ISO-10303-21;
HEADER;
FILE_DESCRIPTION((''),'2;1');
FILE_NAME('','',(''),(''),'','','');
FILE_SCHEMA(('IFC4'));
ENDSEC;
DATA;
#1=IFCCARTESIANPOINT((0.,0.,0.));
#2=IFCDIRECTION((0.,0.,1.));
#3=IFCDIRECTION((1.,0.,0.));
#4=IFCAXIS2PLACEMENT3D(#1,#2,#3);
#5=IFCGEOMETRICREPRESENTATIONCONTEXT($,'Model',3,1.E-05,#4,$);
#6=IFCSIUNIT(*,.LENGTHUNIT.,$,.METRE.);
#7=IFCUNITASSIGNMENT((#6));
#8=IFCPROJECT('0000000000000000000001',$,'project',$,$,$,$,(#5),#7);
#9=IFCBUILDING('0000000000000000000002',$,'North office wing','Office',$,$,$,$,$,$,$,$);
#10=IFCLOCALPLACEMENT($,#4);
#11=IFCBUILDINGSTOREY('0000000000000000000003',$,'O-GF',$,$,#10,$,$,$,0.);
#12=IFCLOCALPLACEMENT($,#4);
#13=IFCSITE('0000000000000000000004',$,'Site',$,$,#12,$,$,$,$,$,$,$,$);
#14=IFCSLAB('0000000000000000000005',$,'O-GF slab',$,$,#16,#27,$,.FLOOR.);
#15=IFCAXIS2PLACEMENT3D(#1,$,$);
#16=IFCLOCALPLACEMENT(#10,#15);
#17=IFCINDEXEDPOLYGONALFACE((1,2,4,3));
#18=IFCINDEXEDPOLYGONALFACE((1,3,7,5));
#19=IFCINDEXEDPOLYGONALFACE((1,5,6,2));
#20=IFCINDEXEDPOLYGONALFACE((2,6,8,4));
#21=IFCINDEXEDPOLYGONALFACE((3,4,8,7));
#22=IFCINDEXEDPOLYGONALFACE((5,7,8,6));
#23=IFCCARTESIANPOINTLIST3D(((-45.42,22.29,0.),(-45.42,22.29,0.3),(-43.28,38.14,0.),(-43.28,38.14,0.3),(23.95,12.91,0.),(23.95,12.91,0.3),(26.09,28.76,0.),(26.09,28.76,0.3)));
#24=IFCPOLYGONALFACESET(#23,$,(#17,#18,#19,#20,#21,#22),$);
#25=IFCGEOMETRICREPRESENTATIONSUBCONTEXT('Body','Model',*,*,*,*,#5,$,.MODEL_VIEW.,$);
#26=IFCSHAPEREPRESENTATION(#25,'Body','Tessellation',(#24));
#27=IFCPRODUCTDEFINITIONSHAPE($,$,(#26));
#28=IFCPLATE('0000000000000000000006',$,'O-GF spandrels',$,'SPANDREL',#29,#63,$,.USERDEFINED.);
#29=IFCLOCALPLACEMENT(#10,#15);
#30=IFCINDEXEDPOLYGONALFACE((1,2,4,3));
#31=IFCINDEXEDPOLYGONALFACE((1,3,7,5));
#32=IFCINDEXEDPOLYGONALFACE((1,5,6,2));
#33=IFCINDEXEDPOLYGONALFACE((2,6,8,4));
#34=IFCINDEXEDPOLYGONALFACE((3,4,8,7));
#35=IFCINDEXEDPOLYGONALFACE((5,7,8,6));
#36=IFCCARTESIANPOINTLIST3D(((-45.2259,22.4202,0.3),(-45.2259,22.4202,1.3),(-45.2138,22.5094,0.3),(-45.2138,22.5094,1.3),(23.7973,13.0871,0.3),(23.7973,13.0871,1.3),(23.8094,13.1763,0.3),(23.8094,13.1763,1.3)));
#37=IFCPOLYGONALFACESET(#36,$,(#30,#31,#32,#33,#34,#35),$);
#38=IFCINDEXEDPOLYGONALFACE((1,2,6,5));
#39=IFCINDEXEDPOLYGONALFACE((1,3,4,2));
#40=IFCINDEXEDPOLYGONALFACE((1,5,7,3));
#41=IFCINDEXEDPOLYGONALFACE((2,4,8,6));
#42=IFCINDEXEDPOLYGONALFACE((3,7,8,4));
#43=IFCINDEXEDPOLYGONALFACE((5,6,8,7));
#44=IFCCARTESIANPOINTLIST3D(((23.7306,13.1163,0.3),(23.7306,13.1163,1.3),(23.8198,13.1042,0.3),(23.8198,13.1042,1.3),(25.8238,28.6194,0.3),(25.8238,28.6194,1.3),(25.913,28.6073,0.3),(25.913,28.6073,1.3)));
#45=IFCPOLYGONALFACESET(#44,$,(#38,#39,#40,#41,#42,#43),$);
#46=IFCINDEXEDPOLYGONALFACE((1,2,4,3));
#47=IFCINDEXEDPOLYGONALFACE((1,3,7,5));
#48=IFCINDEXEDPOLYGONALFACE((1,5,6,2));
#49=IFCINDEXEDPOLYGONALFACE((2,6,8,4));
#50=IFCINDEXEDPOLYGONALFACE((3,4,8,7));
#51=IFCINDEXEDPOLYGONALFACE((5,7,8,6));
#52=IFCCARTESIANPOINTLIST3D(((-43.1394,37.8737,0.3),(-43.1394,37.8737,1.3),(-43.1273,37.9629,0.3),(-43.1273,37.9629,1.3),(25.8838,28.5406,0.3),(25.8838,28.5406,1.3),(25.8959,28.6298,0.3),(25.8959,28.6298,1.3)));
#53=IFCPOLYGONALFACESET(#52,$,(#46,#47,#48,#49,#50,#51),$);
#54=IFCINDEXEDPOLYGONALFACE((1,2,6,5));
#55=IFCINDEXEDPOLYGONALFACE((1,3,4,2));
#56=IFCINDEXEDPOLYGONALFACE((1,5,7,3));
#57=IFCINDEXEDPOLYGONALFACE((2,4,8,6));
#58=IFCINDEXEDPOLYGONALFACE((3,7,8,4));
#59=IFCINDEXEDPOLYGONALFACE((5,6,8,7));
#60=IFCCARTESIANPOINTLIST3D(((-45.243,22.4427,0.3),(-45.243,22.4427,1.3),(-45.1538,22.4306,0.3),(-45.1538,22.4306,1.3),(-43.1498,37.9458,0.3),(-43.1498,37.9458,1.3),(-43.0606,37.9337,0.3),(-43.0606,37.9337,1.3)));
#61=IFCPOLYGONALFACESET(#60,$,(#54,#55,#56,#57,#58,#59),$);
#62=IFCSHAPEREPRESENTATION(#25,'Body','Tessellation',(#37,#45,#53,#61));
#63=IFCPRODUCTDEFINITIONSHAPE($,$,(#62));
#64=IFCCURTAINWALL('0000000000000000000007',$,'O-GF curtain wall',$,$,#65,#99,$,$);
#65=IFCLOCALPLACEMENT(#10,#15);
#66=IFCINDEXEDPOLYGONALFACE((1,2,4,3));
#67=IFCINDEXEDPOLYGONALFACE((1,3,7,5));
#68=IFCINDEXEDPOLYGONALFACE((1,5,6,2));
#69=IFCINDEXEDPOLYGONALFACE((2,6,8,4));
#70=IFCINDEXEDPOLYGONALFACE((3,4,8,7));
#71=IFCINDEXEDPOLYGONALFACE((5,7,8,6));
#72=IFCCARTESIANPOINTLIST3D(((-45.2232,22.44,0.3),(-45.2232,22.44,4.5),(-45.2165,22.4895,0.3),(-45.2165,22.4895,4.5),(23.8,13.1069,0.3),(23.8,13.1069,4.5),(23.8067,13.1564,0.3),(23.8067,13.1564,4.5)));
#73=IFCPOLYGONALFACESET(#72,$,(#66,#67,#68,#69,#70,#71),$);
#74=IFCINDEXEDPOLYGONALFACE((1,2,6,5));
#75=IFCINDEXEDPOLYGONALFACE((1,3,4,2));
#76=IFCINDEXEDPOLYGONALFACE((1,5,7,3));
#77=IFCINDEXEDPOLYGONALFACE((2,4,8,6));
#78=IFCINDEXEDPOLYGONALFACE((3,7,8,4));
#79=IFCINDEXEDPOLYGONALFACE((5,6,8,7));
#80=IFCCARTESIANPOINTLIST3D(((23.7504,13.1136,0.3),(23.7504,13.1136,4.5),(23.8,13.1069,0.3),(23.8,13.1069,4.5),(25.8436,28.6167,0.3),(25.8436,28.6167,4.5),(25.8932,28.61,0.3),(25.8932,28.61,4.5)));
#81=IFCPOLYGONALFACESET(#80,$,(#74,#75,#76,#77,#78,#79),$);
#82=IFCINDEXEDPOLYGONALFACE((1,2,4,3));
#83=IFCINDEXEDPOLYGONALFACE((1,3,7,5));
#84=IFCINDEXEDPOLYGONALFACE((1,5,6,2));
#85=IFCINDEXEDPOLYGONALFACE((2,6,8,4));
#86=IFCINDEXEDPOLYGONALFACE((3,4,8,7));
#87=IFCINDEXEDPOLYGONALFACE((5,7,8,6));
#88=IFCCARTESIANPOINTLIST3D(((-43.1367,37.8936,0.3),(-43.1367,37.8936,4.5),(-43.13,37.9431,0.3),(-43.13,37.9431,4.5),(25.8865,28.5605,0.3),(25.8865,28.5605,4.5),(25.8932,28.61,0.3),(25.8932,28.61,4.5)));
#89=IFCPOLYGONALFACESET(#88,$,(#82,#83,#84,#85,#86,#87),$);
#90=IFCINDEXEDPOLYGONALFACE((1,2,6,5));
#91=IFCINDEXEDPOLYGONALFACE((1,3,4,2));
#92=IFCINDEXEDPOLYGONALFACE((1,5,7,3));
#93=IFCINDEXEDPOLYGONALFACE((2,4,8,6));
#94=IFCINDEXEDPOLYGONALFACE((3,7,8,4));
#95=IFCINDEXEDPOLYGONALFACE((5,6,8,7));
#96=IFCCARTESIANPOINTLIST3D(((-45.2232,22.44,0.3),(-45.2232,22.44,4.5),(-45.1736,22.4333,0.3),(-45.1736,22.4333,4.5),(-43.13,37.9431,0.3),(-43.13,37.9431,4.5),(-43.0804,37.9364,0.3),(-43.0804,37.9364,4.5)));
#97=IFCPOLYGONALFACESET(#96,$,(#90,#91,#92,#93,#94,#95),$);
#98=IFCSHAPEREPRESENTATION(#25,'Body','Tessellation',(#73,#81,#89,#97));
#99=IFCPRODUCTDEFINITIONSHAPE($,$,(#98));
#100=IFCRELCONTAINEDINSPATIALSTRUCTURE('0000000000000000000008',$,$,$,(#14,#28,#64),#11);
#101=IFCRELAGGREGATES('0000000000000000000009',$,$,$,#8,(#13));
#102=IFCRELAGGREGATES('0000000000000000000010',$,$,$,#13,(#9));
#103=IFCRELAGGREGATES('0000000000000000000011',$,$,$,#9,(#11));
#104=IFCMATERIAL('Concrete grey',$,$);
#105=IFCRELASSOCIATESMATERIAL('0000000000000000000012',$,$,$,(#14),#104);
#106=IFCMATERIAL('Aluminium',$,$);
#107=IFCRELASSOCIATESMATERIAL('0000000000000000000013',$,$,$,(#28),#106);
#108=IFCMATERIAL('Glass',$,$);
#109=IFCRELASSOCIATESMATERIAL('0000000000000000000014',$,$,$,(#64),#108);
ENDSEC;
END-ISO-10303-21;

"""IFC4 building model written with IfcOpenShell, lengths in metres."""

from ifc_helpers import new_model, si_unit, frame, origin_with_axes, place, context, subcontext, project, spatial, polyline, outline, extrude, material, element, save


model = new_model("IFC4")

# Units and contexts
model_context = context("Model", 3, precision=1e-05, world=origin_with_axes())
body_context = subcontext(model_context, "Body", "Model", "MODEL_VIEW")
ifc_project = project(units=[si_unit("LENGTHUNIT", "METRE")], contexts=[model_context])

# Site, building, storey
site_placement = place(None, origin_with_axes())
site = spatial("IfcSite", under=ifc_project, at=site_placement, Name="Site")
building = spatial("IfcBuilding", under=site, Name="North office wing", Description="Office")
storey_placement = place(None, origin_with_axes())
storey = spatial("IfcBuildingStorey", under=building, at=storey_placement, Name="O-GF", Elevation=0.0)

# Shared definitions
ifc_material_1 = material(Name="Aluminium")

# Slab
ifc_material_2 = material(Name="Concrete grey")
slab_placement = place(storey_placement, origin_with_axes())
element("IfcSlab", 1, at=slab_placement, inside=storey, material=ifc_material_2, Name="O-GF slab", PredefinedType="FLOOR", context=body_context, shape_type="SweptSolid", body=[
    extrude(outline(polyline([(-45.42, 22.29), (23.95, 12.91), (26.09, 28.76), (-43.28, 38.14), (-45.42, 22.29)])), origin_with_axes(), (0.0, 0.0, 1.0), 0.3),
])

# Plate
plate_placement = place(storey_placement, origin_with_axes())
element("IfcPlate", 2, at=plate_placement, inside=storey, material=ifc_material_1, Name="O-GF spandrels", ObjectType="SPANDREL", PredefinedType="USERDEFINED", context=body_context, shape_type="SweptSolid", body=[
    extrude(outline(polyline([(-45.2259, 22.4202), (23.7973, 13.0871), (23.8094, 13.1763), (-45.2138, 22.5094), (-45.2259, 22.4202)])), frame((0.0, 0.0, 0.3), z_axis=(0.0, 0.0, 1.0), x_axis=(1.0, 0.0, 0.0)), (0.0, 0.0, 1.0), 1.0),
    extrude(outline(polyline([(23.8198, 13.1042), (25.913, 28.6073), (25.8238, 28.6194), (23.7306, 13.1163), (23.8198, 13.1042)])), frame((0.0, 0.0, 0.3), z_axis=(0.0, 0.0, 1.0), x_axis=(1.0, 0.0, 0.0)), (0.0, 0.0, 1.0), 1.0),
    extrude(outline(polyline([(25.8959, 28.6298), (-43.1273, 37.9629), (-43.1394, 37.8737), (25.8838, 28.5406), (25.8959, 28.6298)])), frame((0.0, 0.0, 0.3), z_axis=(0.0, 0.0, 1.0), x_axis=(1.0, 0.0, 0.0)), (0.0, 0.0, 1.0), 1.0),
    extrude(outline(polyline([(-43.1498, 37.9458), (-45.243, 22.4427), (-45.1538, 22.4306), (-43.0606, 37.9337), (-43.1498, 37.9458)])), frame((0.0, 0.0, 0.3), z_axis=(0.0, 0.0, 1.0), x_axis=(1.0, 0.0, 0.0)), (0.0, 0.0, 1.0), 1.0),
])

# Curtain wall
ifc_material_3 = material(Name="Glass")
curtain_wall_placement = place(storey_placement, origin_with_axes())
element("IfcCurtainWall", 3, at=curtain_wall_placement, inside=storey, material=ifc_material_3, Name="O-GF curtain wall", context=body_context, shape_type="SweptSolid", body=[
    extrude(outline(polyline([(-45.2232, 22.44), (23.8, 13.1069), (23.8067, 13.1564), (-45.2165, 22.4895), (-45.2232, 22.44)])), frame((0.0, 0.0, 0.3), z_axis=(0.0, 0.0, 1.0), x_axis=(1.0, 0.0, 0.0)), (0.0, 0.0, 1.0), 4.2),
    extrude(outline(polyline([(23.8, 13.1069), (25.8932, 28.61), (25.8436, 28.6167), (23.7504, 13.1136), (23.8, 13.1069)])), frame((0.0, 0.0, 0.3), z_axis=(0.0, 0.0, 1.0), x_axis=(1.0, 0.0, 0.0)), (0.0, 0.0, 1.0), 4.2),
    extrude(outline(polyline([(25.8932, 28.61), (-43.13, 37.9431), (-43.1367, 37.8936), (25.8865, 28.5605), (25.8932, 28.61)])), frame((0.0, 0.0, 0.3), z_axis=(0.0, 0.0, 1.0), x_axis=(1.0, 0.0, 0.0)), (0.0, 0.0, 1.0), 4.2),
    extrude(outline(polyline([(-43.13, 37.9431), (-45.2232, 22.44), (-45.1736, 22.4333), (-43.0804, 37.9364), (-43.13, 37.9431)])), frame((0.0, 0.0, 0.3), z_axis=(0.0, 0.0, 1.0), x_axis=(1.0, 0.0, 0.0)), (0.0, 0.0, 1.0), 4.2),
])

save(model, "model.ifc")
